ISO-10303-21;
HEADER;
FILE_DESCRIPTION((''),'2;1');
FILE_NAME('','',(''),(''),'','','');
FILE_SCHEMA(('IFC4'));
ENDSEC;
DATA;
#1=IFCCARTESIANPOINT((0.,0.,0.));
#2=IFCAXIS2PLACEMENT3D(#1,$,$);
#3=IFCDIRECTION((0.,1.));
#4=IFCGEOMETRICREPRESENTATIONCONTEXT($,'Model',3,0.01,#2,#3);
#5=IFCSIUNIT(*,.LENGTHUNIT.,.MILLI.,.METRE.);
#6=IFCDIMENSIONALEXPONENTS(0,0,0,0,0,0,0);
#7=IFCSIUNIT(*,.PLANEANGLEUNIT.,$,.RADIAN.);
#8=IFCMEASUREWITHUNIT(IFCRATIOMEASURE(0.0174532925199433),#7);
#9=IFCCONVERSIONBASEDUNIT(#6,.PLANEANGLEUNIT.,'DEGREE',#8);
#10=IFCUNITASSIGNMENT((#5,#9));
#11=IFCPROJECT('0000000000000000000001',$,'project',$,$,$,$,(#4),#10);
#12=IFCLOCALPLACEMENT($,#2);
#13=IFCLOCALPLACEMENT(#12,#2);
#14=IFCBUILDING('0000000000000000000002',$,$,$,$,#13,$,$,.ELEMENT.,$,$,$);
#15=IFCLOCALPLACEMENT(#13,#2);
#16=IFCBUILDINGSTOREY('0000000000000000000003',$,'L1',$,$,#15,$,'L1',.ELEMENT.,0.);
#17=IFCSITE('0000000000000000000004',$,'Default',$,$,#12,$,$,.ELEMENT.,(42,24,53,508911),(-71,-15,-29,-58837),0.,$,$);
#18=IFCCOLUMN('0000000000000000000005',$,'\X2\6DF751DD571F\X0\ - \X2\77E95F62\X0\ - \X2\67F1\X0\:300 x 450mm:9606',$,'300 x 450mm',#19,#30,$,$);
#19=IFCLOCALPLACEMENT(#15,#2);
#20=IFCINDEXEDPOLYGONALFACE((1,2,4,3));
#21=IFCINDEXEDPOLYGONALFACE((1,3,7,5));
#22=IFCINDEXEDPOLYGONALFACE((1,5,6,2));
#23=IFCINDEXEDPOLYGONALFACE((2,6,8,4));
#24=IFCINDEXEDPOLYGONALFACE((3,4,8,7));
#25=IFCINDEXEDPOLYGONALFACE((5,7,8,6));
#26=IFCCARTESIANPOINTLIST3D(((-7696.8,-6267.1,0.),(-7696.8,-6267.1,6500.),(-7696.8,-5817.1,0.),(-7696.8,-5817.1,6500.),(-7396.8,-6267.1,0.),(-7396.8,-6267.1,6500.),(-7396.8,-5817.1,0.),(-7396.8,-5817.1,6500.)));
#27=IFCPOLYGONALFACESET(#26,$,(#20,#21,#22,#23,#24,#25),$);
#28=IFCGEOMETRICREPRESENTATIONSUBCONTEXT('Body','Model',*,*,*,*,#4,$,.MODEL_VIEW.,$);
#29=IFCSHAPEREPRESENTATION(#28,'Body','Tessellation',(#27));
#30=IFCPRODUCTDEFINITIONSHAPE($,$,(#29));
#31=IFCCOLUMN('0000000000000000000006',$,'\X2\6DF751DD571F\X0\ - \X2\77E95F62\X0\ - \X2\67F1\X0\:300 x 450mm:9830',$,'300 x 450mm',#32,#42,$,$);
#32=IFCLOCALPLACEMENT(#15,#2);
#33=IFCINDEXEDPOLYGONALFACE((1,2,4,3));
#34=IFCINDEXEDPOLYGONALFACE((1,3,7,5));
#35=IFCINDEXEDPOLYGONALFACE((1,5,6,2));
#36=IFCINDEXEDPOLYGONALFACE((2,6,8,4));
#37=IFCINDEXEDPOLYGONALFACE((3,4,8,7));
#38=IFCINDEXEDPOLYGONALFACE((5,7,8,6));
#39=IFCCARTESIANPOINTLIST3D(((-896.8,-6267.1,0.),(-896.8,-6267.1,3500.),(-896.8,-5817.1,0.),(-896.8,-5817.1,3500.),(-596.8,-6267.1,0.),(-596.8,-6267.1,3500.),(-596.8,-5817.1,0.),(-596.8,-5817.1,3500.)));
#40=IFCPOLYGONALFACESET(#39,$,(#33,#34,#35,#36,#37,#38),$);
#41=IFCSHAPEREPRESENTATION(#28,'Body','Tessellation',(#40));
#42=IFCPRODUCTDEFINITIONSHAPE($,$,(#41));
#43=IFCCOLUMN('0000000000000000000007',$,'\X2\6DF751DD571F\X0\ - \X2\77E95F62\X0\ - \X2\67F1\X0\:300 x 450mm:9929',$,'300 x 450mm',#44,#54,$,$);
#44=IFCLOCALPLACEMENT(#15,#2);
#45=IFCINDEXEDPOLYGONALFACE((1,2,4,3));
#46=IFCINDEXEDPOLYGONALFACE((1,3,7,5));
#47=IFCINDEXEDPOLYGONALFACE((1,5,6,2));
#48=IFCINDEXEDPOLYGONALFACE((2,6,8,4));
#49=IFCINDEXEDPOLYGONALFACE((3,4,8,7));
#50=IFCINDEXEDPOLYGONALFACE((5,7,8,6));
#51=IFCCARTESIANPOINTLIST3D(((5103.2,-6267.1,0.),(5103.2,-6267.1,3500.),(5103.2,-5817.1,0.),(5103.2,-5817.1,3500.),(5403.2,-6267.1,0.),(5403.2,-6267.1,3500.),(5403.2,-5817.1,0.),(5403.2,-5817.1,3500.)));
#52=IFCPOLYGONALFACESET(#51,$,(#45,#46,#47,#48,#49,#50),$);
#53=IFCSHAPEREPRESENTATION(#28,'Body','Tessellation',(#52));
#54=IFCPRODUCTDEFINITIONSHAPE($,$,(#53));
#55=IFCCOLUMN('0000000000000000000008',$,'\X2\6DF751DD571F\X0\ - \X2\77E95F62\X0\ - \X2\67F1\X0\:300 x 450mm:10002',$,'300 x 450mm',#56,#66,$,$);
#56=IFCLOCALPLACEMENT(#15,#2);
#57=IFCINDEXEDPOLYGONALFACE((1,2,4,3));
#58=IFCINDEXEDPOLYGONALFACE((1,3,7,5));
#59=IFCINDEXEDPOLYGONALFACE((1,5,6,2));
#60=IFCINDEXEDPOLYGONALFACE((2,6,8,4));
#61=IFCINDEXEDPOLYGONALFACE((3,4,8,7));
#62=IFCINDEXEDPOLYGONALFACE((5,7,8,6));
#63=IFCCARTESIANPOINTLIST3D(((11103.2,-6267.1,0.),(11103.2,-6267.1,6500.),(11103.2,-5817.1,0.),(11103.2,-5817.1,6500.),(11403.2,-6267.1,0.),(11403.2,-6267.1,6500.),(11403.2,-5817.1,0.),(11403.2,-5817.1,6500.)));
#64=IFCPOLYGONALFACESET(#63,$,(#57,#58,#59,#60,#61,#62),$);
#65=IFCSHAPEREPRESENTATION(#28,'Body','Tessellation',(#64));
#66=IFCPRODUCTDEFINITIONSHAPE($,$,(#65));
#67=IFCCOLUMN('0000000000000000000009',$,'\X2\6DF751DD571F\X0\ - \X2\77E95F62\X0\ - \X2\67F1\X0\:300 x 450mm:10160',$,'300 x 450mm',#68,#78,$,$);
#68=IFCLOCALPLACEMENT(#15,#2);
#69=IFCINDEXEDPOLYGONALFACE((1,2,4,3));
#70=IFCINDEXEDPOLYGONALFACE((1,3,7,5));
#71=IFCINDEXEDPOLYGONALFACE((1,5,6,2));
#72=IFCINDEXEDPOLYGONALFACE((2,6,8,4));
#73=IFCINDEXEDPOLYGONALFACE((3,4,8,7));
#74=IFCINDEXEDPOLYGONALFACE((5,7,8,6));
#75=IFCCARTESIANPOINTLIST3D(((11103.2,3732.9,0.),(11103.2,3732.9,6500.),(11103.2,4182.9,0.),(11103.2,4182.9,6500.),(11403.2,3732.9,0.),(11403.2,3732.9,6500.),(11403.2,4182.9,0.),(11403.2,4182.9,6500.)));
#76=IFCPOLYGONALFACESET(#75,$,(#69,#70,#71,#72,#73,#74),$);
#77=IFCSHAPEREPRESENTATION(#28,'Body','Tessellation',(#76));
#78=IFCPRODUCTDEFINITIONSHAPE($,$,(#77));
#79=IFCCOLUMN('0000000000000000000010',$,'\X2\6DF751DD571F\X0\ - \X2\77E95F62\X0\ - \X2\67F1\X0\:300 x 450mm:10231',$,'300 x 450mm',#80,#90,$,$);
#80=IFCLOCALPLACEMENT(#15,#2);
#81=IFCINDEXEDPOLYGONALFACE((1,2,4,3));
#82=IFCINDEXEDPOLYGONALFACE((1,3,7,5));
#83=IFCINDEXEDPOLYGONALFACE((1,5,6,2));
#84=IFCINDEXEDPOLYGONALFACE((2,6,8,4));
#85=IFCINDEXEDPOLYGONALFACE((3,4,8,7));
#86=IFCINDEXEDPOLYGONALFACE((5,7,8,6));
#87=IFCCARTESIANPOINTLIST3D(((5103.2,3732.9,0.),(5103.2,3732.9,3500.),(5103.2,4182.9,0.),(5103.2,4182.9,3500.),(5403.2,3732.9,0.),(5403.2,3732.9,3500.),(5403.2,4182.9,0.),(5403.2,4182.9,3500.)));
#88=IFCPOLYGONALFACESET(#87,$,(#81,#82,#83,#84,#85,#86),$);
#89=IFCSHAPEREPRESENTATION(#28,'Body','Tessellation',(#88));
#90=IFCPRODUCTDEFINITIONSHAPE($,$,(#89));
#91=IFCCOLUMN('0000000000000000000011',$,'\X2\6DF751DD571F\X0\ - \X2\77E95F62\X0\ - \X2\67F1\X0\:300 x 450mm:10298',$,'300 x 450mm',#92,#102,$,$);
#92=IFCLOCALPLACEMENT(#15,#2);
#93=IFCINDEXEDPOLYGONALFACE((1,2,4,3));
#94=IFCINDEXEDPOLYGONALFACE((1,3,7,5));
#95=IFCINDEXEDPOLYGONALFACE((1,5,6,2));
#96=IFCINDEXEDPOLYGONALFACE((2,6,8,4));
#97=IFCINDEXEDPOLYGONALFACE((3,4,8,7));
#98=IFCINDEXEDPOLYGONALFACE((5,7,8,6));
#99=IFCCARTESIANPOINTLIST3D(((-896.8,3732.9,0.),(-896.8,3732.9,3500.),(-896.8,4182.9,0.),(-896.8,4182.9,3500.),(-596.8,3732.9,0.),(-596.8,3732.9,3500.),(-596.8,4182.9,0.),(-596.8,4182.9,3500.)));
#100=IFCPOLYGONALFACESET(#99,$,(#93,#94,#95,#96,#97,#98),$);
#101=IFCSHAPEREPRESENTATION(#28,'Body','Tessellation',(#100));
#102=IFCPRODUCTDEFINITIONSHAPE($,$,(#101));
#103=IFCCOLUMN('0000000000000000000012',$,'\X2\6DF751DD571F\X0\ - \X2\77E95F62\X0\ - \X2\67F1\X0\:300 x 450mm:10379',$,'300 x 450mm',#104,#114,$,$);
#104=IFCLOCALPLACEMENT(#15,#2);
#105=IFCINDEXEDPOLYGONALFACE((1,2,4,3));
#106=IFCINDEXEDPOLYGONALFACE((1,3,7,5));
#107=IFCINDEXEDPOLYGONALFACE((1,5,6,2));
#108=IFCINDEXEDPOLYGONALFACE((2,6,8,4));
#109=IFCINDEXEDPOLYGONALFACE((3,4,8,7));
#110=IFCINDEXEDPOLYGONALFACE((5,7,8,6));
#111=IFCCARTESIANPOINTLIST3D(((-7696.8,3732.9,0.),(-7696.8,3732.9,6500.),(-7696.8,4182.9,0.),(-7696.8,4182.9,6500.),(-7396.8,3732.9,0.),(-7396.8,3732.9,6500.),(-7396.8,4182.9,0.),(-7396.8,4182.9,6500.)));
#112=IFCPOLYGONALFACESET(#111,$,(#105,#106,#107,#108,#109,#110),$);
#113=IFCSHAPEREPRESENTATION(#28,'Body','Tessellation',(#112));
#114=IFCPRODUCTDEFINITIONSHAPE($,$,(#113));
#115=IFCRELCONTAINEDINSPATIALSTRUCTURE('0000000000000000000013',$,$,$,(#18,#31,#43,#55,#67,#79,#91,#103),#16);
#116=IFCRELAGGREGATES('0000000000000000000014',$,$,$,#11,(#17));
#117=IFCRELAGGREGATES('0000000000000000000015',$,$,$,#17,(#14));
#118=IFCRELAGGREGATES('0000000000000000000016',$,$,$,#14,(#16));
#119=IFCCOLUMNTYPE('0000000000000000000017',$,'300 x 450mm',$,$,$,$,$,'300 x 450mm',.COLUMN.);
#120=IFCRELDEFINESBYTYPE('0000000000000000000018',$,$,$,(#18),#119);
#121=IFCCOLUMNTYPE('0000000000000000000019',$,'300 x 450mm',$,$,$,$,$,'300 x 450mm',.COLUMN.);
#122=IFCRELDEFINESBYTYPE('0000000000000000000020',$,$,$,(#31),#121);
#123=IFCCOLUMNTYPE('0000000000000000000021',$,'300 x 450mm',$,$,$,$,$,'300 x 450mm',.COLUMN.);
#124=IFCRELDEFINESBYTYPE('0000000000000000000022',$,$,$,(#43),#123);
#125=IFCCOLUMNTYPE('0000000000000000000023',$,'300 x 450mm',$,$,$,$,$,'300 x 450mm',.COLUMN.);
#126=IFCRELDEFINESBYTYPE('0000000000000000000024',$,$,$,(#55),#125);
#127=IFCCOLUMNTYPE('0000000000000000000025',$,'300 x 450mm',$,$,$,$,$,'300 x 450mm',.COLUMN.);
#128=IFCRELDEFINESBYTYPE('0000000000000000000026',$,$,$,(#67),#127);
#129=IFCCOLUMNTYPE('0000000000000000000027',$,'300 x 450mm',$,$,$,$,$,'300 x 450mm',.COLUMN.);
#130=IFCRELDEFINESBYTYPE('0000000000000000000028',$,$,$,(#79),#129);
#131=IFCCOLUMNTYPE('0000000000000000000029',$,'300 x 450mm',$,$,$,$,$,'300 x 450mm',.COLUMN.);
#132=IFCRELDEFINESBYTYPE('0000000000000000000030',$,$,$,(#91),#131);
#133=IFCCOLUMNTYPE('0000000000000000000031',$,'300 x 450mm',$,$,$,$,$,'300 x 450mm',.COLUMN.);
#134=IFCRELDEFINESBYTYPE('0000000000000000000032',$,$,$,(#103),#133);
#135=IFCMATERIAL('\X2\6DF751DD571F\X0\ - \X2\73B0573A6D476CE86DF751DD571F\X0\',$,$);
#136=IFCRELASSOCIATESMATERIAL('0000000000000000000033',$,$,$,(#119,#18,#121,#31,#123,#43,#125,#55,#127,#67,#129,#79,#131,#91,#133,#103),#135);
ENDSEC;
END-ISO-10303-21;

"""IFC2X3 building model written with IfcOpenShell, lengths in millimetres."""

from ifc_helpers import new_model, entity, si_unit, converted_unit, direction, frame, frame_2d, origin, origin_2d_with_axis, place, context, subcontext, project, spatial, rectangle, extrude, source, transform, mapped, material, type_object, type_shapes, element, save


model = new_model("IFC2X3")

# Units and contexts
model_context = context("Model", 3, precision=0.01, world=origin(), true_north=direction((0.0, 1.0)))
body_context = subcontext(model_context, "Body", "Model", "MODEL_VIEW")
ifc_project = project(units=[si_unit("LENGTHUNIT", "METRE", prefix="MILLI"), converted_unit("PLANEANGLEUNIT", "DEGREE", entity("IfcRatioMeasure", 0.0174532925199433), si_unit("PLANEANGLEUNIT", "RADIAN"), dimensions=[0, 0, 0, 0, 0, 0, 0])], contexts=[model_context])

# Site, building, storey
site_placement = place(None, origin())
site = spatial("IfcSite", under=ifc_project, at=site_placement, Name="Default", CompositionType="ELEMENT", RefLatitude=(42, 24, 53, 508911), RefLongitude=(-71, -15, -29, -58837), RefElevation=0.0)
building_placement = place(site_placement, origin())
building = spatial("IfcBuilding", under=site, at=building_placement, CompositionType="ELEMENT")
storey_placement = place(building_placement, origin())
storey = spatial("IfcBuildingStorey", under=building, at=storey_placement, Name="L1", LongName="L1", CompositionType="ELEMENT", Elevation=0.0)

# Columns
ifc_material = material(Name="混凝土 - 现场浇注混凝土")
column_type_1 = type_object("IfcColumnType", Name="300 x 450mm", ElementType="300 x 450mm", PredefinedType="COLUMN", material=ifc_material)
shared_shape_1 = source(origin(), body_context, "Body", "SweptSolid", [
    extrude(rectangle(XDim=450.0, YDim=300.0, at=frame_2d((0.0, 0.0), x_axis=(1.0, 0.0))), frame((-7546.8, -6042.1, 0.0), z_axis=(0.0, 0.0, 1.0), x_axis=(0.0, -1.0, 0.0)), (0.0, 0.0, 1.0), 6500.0),
])
type_shapes(column_type_1, [shared_shape_1])
column_1_placement = place(storey_placement, origin())
element("IfcColumn", 1, at=column_1_placement, inside=storey, type_object=column_type_1, material=ifc_material, Name="混凝土 - 矩形 - 柱:300 x 450mm:9606", ObjectType="300 x 450mm", context=body_context, shape_type="MappedRepresentation", body=[
    mapped(shared_shape_1, transform((0.0, 0.0, 0.0), scale=1.0)),
])
column_type_2 = type_object("IfcColumnType", Name="300 x 450mm", ElementType="300 x 450mm", PredefinedType="COLUMN", material=ifc_material)
shared_shape_2 = source(origin(), body_context, "Body", "SweptSolid", [
    extrude(rectangle(XDim=450.0, YDim=300.0, at=origin_2d_with_axis()), frame((-746.8, -6042.1, 0.0), z_axis=(0.0, 0.0, 1.0), x_axis=(0.0, -1.0, 0.0)), (0.0, 0.0, 1.0), 3500.0),
])
type_shapes(column_type_2, [shared_shape_2])
column_2_placement = place(storey_placement, origin())
element("IfcColumn", 2, at=column_2_placement, inside=storey, type_object=column_type_2, material=ifc_material, Name="混凝土 - 矩形 - 柱:300 x 450mm:9830", ObjectType="300 x 450mm", context=body_context, shape_type="MappedRepresentation", body=[
    mapped(shared_shape_2, transform((0.0, 0.0, 0.0), scale=1.0)),
])
column_type_3 = type_object("IfcColumnType", Name="300 x 450mm", ElementType="300 x 450mm", PredefinedType="COLUMN", material=ifc_material)
shared_shape_3 = source(origin(), body_context, "Body", "SweptSolid", [
    extrude(rectangle(XDim=450.0, YDim=300.0, at=frame_2d((0.0, 0.0), x_axis=(1.0, 0.0))), frame((5253.2, -6042.1, 0.0), z_axis=(0.0, 0.0, 1.0), x_axis=(0.0, -1.0, 0.0)), (0.0, 0.0, 1.0), 3500.0),
])
type_shapes(column_type_3, [shared_shape_3])
column_3_placement = place(storey_placement, origin())
element("IfcColumn", 3, at=column_3_placement, inside=storey, type_object=column_type_3, material=ifc_material, Name="混凝土 - 矩形 - 柱:300 x 450mm:9929", ObjectType="300 x 450mm", context=body_context, shape_type="MappedRepresentation", body=[
    mapped(shared_shape_3, transform((0.0, 0.0, 0.0), scale=1.0)),
])
column_type_4 = type_object("IfcColumnType", Name="300 x 450mm", ElementType="300 x 450mm", PredefinedType="COLUMN", material=ifc_material)
shared_shape_4 = source(origin(), body_context, "Body", "SweptSolid", [
    extrude(rectangle(XDim=450.0, YDim=300.0, at=origin_2d_with_axis()), frame((11253.2, -6042.1, 0.0), z_axis=(0.0, 0.0, 1.0), x_axis=(0.0, -1.0, 0.0)), (0.0, 0.0, 1.0), 6500.0),
])
type_shapes(column_type_4, [shared_shape_4])
column_4_placement = place(storey_placement, origin())
element("IfcColumn", 4, at=column_4_placement, inside=storey, type_object=column_type_4, material=ifc_material, Name="混凝土 - 矩形 - 柱:300 x 450mm:10002", ObjectType="300 x 450mm", context=body_context, shape_type="MappedRepresentation", body=[
    mapped(shared_shape_4, transform((0.0, 0.0, 0.0), scale=1.0)),
])
column_type_5 = type_object("IfcColumnType", Name="300 x 450mm", ElementType="300 x 450mm", PredefinedType="COLUMN", material=ifc_material)
shared_shape_5 = source(origin(), body_context, "Body", "SweptSolid", [
    extrude(rectangle(XDim=450.0, YDim=300.0, at=frame_2d((0.0, 0.0), x_axis=(1.0, 0.0))), frame((11253.2, 3957.9, 0.0), z_axis=(0.0, 0.0, 1.0), x_axis=(0.0, -1.0, 0.0)), (0.0, 0.0, 1.0), 6500.0),
])
type_shapes(column_type_5, [shared_shape_5])
column_5_placement = place(storey_placement, origin())
element("IfcColumn", 5, at=column_5_placement, inside=storey, type_object=column_type_5, material=ifc_material, Name="混凝土 - 矩形 - 柱:300 x 450mm:10160", ObjectType="300 x 450mm", context=body_context, shape_type="MappedRepresentation", body=[
    mapped(shared_shape_5, transform((0.0, 0.0, 0.0), scale=1.0)),
])
column_type_6 = type_object("IfcColumnType", Name="300 x 450mm", ElementType="300 x 450mm", PredefinedType="COLUMN", material=ifc_material)
shared_shape_6 = source(origin(), body_context, "Body", "SweptSolid", [
    extrude(rectangle(XDim=450.0, YDim=300.0, at=frame_2d((0.0, 0.0), x_axis=(1.0, 0.0))), frame((5253.2, 3957.9, 0.0), z_axis=(0.0, 0.0, 1.0), x_axis=(0.0, -1.0, 0.0)), (0.0, 0.0, 1.0), 3500.0),
])
type_shapes(column_type_6, [shared_shape_6])
column_6_placement = place(storey_placement, origin())
element("IfcColumn", 6, at=column_6_placement, inside=storey, type_object=column_type_6, material=ifc_material, Name="混凝土 - 矩形 - 柱:300 x 450mm:10231", ObjectType="300 x 450mm", context=body_context, shape_type="MappedRepresentation", body=[
    mapped(shared_shape_6, transform((0.0, 0.0, 0.0), scale=1.0)),
])
column_type_7 = type_object("IfcColumnType", Name="300 x 450mm", ElementType="300 x 450mm", PredefinedType="COLUMN", material=ifc_material)
shared_shape_7 = source(origin(), body_context, "Body", "SweptSolid", [
    extrude(rectangle(XDim=450.0, YDim=300.0, at=frame_2d((0.0, 0.0), x_axis=(1.0, 0.0))), frame((-746.8, 3957.9, 0.0), z_axis=(0.0, 0.0, 1.0), x_axis=(0.0, -1.0, 0.0)), (0.0, 0.0, 1.0), 3500.0),
])
type_shapes(column_type_7, [shared_shape_7])
column_7_placement = place(storey_placement, origin())
element("IfcColumn", 7, at=column_7_placement, inside=storey, type_object=column_type_7, material=ifc_material, Name="混凝土 - 矩形 - 柱:300 x 450mm:10298", ObjectType="300 x 450mm", context=body_context, shape_type="MappedRepresentation", body=[
    mapped(shared_shape_7, transform((0.0, 0.0, 0.0), scale=1.0)),
])
column_type_8 = type_object("IfcColumnType", Name="300 x 450mm", ElementType="300 x 450mm", PredefinedType="COLUMN", material=ifc_material)
shared_shape_8 = source(origin(), body_context, "Body", "SweptSolid", [
    extrude(rectangle(XDim=450.0, YDim=300.0, at=frame_2d((0.0, 0.0), x_axis=(1.0, 0.0))), frame((-7546.8, 3957.9, 0.0), z_axis=(0.0, 0.0, 1.0), x_axis=(0.0, -1.0, 0.0)), (0.0, 0.0, 1.0), 6500.0),
])
type_shapes(column_type_8, [shared_shape_8])
column_8_placement = place(storey_placement, origin())
element("IfcColumn", 8, at=column_8_placement, inside=storey, type_object=column_type_8, material=ifc_material, Name="混凝土 - 矩形 - 柱:300 x 450mm:10379", ObjectType="300 x 450mm", context=body_context, shape_type="MappedRepresentation", body=[
    mapped(shared_shape_8, transform((0.0, 0.0, 0.0), scale=1.0)),
])

save(model, "model.ifc")
